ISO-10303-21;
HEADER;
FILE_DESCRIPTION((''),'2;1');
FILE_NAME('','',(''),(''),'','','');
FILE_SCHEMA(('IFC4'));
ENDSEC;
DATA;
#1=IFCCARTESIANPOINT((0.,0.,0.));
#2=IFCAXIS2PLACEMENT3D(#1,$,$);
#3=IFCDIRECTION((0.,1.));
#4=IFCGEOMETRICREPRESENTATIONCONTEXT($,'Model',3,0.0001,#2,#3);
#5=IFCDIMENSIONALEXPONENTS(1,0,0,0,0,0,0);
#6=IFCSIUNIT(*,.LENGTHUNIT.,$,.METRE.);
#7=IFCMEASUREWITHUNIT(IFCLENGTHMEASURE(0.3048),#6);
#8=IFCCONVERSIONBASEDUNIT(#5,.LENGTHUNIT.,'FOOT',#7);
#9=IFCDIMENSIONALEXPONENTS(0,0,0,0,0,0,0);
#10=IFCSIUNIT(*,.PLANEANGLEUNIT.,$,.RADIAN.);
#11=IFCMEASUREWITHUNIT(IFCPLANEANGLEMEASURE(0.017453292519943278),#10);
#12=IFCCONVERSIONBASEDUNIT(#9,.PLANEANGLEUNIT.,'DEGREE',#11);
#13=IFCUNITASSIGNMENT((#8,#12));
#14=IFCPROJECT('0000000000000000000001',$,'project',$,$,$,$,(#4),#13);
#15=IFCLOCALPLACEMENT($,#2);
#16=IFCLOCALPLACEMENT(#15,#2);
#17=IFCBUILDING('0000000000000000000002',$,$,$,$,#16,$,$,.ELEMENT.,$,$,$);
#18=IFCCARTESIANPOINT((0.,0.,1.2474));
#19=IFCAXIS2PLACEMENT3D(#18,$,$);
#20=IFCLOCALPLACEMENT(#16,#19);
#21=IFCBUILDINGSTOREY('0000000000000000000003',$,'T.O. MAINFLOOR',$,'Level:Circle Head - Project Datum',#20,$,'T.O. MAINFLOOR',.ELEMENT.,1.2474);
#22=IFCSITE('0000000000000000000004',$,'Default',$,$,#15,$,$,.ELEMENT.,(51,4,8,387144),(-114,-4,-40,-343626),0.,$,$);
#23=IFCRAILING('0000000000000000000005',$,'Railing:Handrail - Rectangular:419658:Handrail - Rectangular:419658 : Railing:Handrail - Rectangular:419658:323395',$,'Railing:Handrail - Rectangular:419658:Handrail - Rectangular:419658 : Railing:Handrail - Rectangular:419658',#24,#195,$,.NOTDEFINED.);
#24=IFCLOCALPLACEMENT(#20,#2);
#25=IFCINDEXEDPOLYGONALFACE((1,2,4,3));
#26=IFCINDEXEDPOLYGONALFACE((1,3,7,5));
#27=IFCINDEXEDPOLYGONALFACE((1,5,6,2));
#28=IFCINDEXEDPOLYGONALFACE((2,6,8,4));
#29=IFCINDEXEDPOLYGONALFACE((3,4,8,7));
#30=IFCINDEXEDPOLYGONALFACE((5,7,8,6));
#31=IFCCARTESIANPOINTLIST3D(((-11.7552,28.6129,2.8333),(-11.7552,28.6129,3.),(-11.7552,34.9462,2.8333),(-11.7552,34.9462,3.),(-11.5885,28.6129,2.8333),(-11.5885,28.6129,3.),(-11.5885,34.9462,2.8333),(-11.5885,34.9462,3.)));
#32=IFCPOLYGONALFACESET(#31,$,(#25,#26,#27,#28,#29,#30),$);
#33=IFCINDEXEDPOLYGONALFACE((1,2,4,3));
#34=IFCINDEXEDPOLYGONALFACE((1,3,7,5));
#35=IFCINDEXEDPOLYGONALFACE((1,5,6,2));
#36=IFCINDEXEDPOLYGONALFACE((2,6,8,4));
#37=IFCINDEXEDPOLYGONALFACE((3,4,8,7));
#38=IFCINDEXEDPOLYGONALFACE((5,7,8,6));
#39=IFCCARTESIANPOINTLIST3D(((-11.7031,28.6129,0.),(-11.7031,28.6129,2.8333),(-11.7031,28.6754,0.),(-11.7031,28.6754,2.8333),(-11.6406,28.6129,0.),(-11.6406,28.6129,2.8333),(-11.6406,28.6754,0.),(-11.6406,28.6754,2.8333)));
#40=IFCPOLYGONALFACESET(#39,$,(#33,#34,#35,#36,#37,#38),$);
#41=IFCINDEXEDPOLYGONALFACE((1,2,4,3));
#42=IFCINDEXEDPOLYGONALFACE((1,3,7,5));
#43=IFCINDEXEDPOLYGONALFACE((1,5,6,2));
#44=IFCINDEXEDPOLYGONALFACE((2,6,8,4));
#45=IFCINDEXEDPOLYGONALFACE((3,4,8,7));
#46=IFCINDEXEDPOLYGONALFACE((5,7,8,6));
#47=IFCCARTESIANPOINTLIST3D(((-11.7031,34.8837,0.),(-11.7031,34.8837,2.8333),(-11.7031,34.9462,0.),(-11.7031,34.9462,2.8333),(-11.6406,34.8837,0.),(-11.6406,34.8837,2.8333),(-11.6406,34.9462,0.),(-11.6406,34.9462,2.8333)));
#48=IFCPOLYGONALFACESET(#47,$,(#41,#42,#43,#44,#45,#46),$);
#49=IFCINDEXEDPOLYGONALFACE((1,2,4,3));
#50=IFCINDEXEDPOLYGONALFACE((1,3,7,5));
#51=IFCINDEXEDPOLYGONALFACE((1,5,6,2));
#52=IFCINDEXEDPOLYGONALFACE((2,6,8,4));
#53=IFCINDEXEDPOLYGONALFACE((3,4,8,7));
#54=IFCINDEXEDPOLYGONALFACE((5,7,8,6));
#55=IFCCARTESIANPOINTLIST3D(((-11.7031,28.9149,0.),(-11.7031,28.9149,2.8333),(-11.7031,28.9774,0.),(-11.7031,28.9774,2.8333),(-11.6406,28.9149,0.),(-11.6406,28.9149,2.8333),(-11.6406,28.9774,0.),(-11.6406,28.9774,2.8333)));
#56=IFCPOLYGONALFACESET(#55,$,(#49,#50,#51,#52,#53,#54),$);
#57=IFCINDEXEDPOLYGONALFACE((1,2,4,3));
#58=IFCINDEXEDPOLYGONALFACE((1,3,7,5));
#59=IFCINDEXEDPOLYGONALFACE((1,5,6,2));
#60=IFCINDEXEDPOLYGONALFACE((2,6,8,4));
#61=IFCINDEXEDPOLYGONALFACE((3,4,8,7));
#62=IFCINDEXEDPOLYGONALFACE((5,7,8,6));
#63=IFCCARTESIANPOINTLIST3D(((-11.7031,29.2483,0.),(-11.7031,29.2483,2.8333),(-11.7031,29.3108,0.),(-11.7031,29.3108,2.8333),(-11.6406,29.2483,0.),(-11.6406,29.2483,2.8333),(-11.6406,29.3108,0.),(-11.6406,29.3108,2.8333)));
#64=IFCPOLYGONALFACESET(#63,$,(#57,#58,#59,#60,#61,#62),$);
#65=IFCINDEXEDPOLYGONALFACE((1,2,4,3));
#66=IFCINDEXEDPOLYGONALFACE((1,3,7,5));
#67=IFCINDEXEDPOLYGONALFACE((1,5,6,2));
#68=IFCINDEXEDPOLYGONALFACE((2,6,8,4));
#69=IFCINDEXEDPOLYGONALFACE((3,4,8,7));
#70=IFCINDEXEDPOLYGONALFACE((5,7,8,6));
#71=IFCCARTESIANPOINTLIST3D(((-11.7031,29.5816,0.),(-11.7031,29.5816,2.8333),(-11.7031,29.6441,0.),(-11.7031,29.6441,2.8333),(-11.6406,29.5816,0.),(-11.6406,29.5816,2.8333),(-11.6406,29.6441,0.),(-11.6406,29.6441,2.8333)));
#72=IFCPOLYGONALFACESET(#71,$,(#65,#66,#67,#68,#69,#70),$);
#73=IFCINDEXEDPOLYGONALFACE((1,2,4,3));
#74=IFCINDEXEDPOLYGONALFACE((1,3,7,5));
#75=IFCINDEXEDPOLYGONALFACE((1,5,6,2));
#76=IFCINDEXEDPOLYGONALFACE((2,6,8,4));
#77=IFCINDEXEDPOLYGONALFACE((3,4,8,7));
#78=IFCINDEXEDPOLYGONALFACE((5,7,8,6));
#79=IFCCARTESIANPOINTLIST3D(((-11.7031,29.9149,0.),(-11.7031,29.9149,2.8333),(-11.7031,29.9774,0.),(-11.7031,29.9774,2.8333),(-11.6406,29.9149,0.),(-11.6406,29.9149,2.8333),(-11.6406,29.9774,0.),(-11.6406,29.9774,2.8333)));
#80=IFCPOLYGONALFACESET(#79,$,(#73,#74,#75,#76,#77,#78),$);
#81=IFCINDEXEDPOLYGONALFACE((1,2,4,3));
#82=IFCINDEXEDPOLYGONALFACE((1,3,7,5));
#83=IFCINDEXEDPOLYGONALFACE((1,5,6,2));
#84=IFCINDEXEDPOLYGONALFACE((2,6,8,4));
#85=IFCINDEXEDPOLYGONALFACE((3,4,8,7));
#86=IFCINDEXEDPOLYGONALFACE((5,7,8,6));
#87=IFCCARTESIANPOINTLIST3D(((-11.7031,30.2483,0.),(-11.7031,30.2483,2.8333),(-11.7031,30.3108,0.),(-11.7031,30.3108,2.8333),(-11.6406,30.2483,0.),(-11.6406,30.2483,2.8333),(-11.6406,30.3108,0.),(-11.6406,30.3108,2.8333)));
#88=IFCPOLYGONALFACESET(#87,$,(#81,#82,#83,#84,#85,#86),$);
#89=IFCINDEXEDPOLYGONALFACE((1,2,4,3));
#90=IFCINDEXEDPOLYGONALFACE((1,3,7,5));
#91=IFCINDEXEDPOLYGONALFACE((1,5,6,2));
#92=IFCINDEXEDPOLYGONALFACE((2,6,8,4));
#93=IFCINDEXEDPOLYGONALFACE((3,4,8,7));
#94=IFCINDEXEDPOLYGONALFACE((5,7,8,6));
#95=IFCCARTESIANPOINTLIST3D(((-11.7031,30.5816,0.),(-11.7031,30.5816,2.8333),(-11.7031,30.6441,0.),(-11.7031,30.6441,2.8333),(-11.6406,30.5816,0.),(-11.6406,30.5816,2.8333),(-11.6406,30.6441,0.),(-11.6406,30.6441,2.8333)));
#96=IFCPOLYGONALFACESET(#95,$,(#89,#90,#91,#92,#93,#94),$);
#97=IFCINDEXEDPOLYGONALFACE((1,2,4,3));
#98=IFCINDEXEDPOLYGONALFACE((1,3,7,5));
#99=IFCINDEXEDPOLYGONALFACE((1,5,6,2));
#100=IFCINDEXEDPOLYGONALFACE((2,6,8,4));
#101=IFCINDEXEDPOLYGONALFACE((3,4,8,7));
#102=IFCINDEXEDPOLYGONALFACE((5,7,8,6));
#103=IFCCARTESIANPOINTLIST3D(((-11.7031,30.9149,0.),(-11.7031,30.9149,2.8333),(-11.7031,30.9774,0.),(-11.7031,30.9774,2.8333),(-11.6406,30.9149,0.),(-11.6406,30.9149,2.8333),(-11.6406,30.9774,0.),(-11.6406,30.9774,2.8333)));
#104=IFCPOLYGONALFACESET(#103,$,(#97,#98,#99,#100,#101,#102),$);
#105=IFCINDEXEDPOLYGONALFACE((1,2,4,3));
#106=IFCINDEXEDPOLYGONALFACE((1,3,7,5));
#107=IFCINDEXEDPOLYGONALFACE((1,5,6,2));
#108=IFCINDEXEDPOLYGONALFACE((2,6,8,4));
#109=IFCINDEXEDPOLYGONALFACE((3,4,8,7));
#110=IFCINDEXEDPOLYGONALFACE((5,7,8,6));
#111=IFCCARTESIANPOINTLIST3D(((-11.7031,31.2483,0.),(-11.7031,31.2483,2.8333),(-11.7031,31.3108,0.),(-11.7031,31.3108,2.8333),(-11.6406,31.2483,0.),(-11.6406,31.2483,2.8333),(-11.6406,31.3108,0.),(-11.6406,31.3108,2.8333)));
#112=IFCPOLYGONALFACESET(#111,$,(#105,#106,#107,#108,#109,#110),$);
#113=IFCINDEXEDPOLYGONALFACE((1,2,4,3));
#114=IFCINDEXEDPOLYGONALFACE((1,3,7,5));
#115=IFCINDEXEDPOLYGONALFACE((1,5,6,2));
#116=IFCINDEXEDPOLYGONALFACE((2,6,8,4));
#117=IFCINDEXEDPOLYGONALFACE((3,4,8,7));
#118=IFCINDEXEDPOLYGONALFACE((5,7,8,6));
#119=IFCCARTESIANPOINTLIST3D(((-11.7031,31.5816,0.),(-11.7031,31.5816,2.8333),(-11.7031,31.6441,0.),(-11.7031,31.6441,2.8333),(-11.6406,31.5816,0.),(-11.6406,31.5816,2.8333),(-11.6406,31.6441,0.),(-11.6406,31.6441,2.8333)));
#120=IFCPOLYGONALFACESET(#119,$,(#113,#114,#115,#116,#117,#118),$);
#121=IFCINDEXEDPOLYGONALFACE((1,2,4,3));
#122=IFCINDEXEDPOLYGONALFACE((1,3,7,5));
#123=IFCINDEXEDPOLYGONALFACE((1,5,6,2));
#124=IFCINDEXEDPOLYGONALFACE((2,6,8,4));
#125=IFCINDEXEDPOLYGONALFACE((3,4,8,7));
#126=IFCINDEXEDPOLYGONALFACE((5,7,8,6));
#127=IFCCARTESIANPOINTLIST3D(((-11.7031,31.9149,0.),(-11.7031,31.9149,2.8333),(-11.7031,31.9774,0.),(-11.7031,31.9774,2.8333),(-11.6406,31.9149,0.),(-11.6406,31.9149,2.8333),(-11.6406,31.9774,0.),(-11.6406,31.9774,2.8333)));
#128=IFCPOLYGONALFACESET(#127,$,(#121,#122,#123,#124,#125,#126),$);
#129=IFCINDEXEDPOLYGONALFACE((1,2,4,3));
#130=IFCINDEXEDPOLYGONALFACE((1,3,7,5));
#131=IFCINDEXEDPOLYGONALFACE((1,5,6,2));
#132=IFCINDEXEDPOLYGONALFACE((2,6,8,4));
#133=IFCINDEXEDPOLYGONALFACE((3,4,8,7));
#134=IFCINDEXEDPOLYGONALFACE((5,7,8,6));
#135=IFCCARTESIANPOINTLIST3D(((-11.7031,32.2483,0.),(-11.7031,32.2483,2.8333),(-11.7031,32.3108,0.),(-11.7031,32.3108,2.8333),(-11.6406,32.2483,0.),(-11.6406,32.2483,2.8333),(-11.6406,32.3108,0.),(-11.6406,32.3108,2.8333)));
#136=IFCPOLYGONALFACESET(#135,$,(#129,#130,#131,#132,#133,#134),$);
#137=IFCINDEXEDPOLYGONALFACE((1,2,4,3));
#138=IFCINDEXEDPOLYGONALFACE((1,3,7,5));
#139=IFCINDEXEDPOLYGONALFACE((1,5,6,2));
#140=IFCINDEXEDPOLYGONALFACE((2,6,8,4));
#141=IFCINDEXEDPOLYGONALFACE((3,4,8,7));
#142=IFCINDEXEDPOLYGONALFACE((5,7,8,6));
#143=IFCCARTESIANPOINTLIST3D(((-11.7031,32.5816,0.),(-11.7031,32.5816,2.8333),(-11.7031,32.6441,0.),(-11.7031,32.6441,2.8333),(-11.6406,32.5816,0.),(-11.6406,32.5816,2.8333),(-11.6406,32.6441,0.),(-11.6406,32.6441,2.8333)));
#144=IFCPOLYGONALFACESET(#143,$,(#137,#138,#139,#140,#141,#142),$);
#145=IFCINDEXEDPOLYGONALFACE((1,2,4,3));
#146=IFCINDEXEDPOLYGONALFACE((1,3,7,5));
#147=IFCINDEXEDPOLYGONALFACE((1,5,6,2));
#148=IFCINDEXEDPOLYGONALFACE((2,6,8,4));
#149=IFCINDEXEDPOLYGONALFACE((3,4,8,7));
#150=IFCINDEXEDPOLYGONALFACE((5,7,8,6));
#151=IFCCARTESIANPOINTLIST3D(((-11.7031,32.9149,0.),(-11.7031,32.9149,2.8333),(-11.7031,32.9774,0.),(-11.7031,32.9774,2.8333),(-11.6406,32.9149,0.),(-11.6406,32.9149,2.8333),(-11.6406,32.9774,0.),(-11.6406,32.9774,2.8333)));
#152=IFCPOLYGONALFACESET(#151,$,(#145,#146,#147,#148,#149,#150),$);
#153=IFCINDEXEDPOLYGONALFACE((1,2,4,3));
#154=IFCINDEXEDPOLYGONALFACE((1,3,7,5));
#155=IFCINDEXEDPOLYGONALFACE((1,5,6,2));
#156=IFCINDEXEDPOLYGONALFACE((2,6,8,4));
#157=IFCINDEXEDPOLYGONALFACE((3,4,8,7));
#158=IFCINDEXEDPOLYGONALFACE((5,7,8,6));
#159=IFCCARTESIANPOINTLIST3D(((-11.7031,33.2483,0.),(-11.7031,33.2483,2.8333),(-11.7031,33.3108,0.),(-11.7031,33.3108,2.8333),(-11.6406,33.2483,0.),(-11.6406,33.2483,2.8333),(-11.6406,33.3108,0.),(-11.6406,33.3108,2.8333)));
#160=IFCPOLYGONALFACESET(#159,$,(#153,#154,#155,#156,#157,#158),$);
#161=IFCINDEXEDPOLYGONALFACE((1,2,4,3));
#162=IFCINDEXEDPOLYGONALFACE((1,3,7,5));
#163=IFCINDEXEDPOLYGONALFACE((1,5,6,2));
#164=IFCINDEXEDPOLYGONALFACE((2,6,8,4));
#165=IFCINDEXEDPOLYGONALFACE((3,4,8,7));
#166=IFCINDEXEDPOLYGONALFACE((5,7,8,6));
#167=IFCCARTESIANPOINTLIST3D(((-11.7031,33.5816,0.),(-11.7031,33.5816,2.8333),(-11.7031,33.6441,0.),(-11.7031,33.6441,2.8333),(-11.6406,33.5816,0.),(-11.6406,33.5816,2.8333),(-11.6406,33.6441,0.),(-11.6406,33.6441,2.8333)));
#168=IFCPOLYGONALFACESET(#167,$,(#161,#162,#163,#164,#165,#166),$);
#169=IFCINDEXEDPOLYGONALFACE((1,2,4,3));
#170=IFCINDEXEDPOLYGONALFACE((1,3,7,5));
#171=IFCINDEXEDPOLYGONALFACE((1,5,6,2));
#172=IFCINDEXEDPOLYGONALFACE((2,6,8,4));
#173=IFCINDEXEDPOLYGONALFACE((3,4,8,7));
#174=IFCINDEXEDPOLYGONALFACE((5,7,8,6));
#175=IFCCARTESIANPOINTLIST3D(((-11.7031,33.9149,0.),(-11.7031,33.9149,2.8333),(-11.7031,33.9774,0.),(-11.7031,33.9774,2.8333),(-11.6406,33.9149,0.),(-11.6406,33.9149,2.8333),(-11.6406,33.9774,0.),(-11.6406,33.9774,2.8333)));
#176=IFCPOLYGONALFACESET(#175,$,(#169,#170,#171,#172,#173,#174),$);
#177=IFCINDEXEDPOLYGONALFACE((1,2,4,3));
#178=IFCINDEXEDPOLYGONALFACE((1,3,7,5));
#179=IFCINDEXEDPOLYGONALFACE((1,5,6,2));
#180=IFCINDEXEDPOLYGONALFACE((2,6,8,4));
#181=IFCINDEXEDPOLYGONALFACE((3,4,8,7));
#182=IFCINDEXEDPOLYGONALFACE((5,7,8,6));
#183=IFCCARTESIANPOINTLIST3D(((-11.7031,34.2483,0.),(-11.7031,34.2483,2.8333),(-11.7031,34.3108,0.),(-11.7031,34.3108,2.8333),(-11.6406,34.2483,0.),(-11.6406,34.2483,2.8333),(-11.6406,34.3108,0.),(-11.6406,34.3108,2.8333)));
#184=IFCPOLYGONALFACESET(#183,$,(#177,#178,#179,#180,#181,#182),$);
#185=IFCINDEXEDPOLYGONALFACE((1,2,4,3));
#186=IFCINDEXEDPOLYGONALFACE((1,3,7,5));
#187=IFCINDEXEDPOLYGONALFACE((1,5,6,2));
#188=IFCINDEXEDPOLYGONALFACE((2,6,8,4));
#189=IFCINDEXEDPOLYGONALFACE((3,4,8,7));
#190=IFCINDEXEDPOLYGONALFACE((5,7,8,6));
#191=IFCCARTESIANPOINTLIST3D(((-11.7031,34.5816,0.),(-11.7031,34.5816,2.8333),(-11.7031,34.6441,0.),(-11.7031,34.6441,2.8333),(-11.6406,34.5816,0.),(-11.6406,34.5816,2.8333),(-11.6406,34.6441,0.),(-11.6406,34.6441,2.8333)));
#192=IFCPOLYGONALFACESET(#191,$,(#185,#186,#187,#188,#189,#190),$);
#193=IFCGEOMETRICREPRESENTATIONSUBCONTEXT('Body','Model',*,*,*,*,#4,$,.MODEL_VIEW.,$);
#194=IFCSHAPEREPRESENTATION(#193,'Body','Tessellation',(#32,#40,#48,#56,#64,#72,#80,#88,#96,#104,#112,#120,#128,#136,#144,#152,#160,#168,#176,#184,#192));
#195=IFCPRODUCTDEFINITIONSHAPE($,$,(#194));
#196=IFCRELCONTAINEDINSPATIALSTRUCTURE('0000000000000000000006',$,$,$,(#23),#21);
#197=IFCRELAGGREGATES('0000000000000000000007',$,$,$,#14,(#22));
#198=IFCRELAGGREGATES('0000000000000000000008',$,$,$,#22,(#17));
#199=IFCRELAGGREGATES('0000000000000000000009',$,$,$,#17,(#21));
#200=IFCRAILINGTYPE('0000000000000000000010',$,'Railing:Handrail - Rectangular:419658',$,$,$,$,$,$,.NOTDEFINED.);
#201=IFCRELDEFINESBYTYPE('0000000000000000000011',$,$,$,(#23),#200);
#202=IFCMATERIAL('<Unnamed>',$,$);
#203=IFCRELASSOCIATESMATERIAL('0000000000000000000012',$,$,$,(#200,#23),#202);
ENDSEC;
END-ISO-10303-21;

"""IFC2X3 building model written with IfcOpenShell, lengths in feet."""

from ifc_helpers import new_model, entity, si_unit, converted_unit, direction, frame, origin, origin_2d_with_axis, place, context, subcontext, project, spatial, rectangle, extrude, source, transform, mapped, material, type_object, type_shapes, element, save


model = new_model("IFC2X3")

# Units and contexts
model_context = context("Model", 3, precision=0.0001, world=origin(), true_north=direction((0.0, 1.0)))
body_context = subcontext(model_context, "Body", "Model", "MODEL_VIEW")
ifc_project = project(units=[converted_unit("LENGTHUNIT", "FOOT", entity("IfcLengthMeasure", 0.3048), si_unit("LENGTHUNIT", "METRE"), dimensions=[1, 0, 0, 0, 0, 0, 0]), converted_unit("PLANEANGLEUNIT", "DEGREE", entity("IfcPlaneAngleMeasure", 0.017453292519943278), si_unit("PLANEANGLEUNIT", "RADIAN"), dimensions=[0, 0, 0, 0, 0, 0, 0])], contexts=[model_context])

# Site, building, storey
site_placement = place(None, origin())
site = spatial("IfcSite", under=ifc_project, at=site_placement, Name="Default", CompositionType="ELEMENT", RefLatitude=(51, 4, 8, 387144), RefLongitude=(-114, -4, -40, -343626), RefElevation=0.0)
building_placement = place(site_placement, origin())
building = spatial("IfcBuilding", under=site, at=building_placement, CompositionType="ELEMENT")
storey_placement = place(building_placement, frame((0.0, 0.0, 1.2474)))
storey = spatial("IfcBuildingStorey", under=building, at=storey_placement, Name="T.O. MAINFLOOR", ObjectType="Level:Circle Head - Project Datum", LongName="T.O. MAINFLOOR", CompositionType="ELEMENT", Elevation=1.2474)

# Railing
ifc_material_1 = material(Name="<Unnamed>")
railing_type = type_object("IfcRailingType", Name="Railing:Handrail - Rectangular:419658", PredefinedType="NOTDEFINED", material=ifc_material_1)
shared_shape_1 = source(origin(), body_context, "Body", "SweptSolid", [
    extrude(rectangle(XDim=0.1667, YDim=6.3333, at=origin_2d_with_axis()), frame((-11.6719, 31.7795, 4.0807), z_axis=(0.0, 0.0, 1.0), x_axis=(-1.0, 0.0, 0.0)), (0.0, 0.0, 1.0), 0.1667),
    extrude(rectangle(XDim=0.0625, YDim=0.0625, at=origin_2d_with_axis()), frame((-11.6719, 28.6441, 1.2474), z_axis=(0.0, 0.0, 1.0), x_axis=(-1.0, 0.0, 0.0)), (0.0, 0.0, 1.0), 2.8333),
    extrude(rectangle(XDim=0.0625, YDim=0.0625, at=origin_2d_with_axis()), frame((-11.6719, 34.9149, 1.2474), z_axis=(0.0, 0.0, 1.0), x_axis=(-1.0, 0.0, 0.0)), (0.0, 0.0, 1.0), 2.8333),
    extrude(rectangle(XDim=0.0625, YDim=0.0625, at=origin_2d_with_axis()), frame((-11.6719, 28.9462, 1.2474), z_axis=(0.0, 0.0, 1.0), x_axis=(-1.0, 0.0, 0.0)), (0.0, 0.0, 1.0), 2.8333),
    extrude(rectangle(XDim=0.0625, YDim=0.0625, at=origin_2d_with_axis()), frame((-11.6719, 29.2795, 1.2474), z_axis=(0.0, 0.0, 1.0), x_axis=(-1.0, 0.0, 0.0)), (0.0, 0.0, 1.0), 2.8333),
    extrude(rectangle(XDim=0.0625, YDim=0.0625, at=origin_2d_with_axis()), frame((-11.6719, 29.6129, 1.2474), z_axis=(0.0, 0.0, 1.0), x_axis=(-1.0, 0.0, 0.0)), (0.0, 0.0, 1.0), 2.8333),
    extrude(rectangle(XDim=0.0625, YDim=0.0625, at=origin_2d_with_axis()), frame((-11.6719, 29.9462, 1.2474), z_axis=(0.0, 0.0, 1.0), x_axis=(-1.0, 0.0, 0.0)), (0.0, 0.0, 1.0), 2.8333),
    extrude(rectangle(XDim=0.0625, YDim=0.0625, at=origin_2d_with_axis()), frame((-11.6719, 30.2795, 1.2474), z_axis=(0.0, 0.0, 1.0), x_axis=(-1.0, 0.0, 0.0)), (0.0, 0.0, 1.0), 2.8333),
    extrude(rectangle(XDim=0.0625, YDim=0.0625, at=origin_2d_with_axis()), frame((-11.6719, 30.6129, 1.2474), z_axis=(0.0, 0.0, 1.0), x_axis=(-1.0, 0.0, 0.0)), (0.0, 0.0, 1.0), 2.8333),
    extrude(rectangle(XDim=0.0625, YDim=0.0625, at=origin_2d_with_axis()), frame((-11.6719, 30.9462, 1.2474), z_axis=(0.0, 0.0, 1.0), x_axis=(-1.0, 0.0, 0.0)), (0.0, 0.0, 1.0), 2.8333),
    extrude(rectangle(XDim=0.0625, YDim=0.0625, at=origin_2d_with_axis()), frame((-11.6719, 31.2795, 1.2474), z_axis=(0.0, 0.0, 1.0), x_axis=(-1.0, 0.0, 0.0)), (0.0, 0.0, 1.0), 2.8333),
    extrude(rectangle(XDim=0.0625, YDim=0.0625, at=origin_2d_with_axis()), frame((-11.6719, 31.6129, 1.2474), z_axis=(0.0, 0.0, 1.0), x_axis=(-1.0, 0.0, 0.0)), (0.0, 0.0, 1.0), 2.8333),
    extrude(rectangle(XDim=0.0625, YDim=0.0625, at=origin_2d_with_axis()), frame((-11.6719, 31.9462, 1.2474), z_axis=(0.0, 0.0, 1.0), x_axis=(-1.0, 0.0, 0.0)), (0.0, 0.0, 1.0), 2.8333),
    extrude(rectangle(XDim=0.0625, YDim=0.0625, at=origin_2d_with_axis()), frame((-11.6719, 32.2795, 1.2474), z_axis=(0.0, 0.0, 1.0), x_axis=(-1.0, 0.0, 0.0)), (0.0, 0.0, 1.0), 2.8333),
    extrude(rectangle(XDim=0.0625, YDim=0.0625, at=origin_2d_with_axis()), frame((-11.6719, 32.6129, 1.2474), z_axis=(0.0, 0.0, 1.0), x_axis=(-1.0, 0.0, 0.0)), (0.0, 0.0, 1.0), 2.8333),
    extrude(rectangle(XDim=0.0625, YDim=0.0625, at=origin_2d_with_axis()), frame((-11.6719, 32.9462, 1.2474), z_axis=(0.0, 0.0, 1.0), x_axis=(-1.0, 0.0, 0.0)), (0.0, 0.0, 1.0), 2.8333),
    extrude(rectangle(XDim=0.0625, YDim=0.0625, at=origin_2d_with_axis()), frame((-11.6719, 33.2795, 1.2474), z_axis=(0.0, 0.0, 1.0), x_axis=(-1.0, 0.0, 0.0)), (0.0, 0.0, 1.0), 2.8333),
    extrude(rectangle(XDim=0.0625, YDim=0.0625, at=origin_2d_with_axis()), frame((-11.6719, 33.6129, 1.2474), z_axis=(0.0, 0.0, 1.0), x_axis=(-1.0, 0.0, 0.0)), (0.0, 0.0, 1.0), 2.8333),
    extrude(rectangle(XDim=0.0625, YDim=0.0625, at=origin_2d_with_axis()), frame((-11.6719, 33.9462, 1.2474), z_axis=(0.0, 0.0, 1.0), x_axis=(-1.0, 0.0, 0.0)), (0.0, 0.0, 1.0), 2.8333),
    extrude(rectangle(XDim=0.0625, YDim=0.0625, at=origin_2d_with_axis()), frame((-11.6719, 34.2795, 1.2474), z_axis=(0.0, 0.0, 1.0), x_axis=(-1.0, 0.0, 0.0)), (0.0, 0.0, 1.0), 2.8333),
    extrude(rectangle(XDim=0.0625, YDim=0.0625, at=origin_2d_with_axis()), frame((-11.6719, 34.6129, 1.2474), z_axis=(0.0, 0.0, 1.0), x_axis=(-1.0, 0.0, 0.0)), (0.0, 0.0, 1.0), 2.8333),
])
type_shapes(railing_type, [shared_shape_1])
railing_placement = place(storey_placement, frame((0.0, 0.0, -1.2474)))
element("IfcRailing", 1, at=railing_placement, inside=storey, type_object=railing_type, material=ifc_material_1, Name="Railing:Handrail - Rectangular:419658:Handrail - Rectangular:419658 : Railing:Handrail - Rectangular:419658:323395", ObjectType="Railing:Handrail - Rectangular:419658:Handrail - Rectangular:419658 : Railing:Handrail - Rectangular:419658", PredefinedType="NOTDEFINED", context=body_context, shape_type="MappedRepresentation", body=[
    mapped(shared_shape_1, transform((0.0, 0.0, 0.0), scale=1.0)),
])

save(model, "model.ifc")
